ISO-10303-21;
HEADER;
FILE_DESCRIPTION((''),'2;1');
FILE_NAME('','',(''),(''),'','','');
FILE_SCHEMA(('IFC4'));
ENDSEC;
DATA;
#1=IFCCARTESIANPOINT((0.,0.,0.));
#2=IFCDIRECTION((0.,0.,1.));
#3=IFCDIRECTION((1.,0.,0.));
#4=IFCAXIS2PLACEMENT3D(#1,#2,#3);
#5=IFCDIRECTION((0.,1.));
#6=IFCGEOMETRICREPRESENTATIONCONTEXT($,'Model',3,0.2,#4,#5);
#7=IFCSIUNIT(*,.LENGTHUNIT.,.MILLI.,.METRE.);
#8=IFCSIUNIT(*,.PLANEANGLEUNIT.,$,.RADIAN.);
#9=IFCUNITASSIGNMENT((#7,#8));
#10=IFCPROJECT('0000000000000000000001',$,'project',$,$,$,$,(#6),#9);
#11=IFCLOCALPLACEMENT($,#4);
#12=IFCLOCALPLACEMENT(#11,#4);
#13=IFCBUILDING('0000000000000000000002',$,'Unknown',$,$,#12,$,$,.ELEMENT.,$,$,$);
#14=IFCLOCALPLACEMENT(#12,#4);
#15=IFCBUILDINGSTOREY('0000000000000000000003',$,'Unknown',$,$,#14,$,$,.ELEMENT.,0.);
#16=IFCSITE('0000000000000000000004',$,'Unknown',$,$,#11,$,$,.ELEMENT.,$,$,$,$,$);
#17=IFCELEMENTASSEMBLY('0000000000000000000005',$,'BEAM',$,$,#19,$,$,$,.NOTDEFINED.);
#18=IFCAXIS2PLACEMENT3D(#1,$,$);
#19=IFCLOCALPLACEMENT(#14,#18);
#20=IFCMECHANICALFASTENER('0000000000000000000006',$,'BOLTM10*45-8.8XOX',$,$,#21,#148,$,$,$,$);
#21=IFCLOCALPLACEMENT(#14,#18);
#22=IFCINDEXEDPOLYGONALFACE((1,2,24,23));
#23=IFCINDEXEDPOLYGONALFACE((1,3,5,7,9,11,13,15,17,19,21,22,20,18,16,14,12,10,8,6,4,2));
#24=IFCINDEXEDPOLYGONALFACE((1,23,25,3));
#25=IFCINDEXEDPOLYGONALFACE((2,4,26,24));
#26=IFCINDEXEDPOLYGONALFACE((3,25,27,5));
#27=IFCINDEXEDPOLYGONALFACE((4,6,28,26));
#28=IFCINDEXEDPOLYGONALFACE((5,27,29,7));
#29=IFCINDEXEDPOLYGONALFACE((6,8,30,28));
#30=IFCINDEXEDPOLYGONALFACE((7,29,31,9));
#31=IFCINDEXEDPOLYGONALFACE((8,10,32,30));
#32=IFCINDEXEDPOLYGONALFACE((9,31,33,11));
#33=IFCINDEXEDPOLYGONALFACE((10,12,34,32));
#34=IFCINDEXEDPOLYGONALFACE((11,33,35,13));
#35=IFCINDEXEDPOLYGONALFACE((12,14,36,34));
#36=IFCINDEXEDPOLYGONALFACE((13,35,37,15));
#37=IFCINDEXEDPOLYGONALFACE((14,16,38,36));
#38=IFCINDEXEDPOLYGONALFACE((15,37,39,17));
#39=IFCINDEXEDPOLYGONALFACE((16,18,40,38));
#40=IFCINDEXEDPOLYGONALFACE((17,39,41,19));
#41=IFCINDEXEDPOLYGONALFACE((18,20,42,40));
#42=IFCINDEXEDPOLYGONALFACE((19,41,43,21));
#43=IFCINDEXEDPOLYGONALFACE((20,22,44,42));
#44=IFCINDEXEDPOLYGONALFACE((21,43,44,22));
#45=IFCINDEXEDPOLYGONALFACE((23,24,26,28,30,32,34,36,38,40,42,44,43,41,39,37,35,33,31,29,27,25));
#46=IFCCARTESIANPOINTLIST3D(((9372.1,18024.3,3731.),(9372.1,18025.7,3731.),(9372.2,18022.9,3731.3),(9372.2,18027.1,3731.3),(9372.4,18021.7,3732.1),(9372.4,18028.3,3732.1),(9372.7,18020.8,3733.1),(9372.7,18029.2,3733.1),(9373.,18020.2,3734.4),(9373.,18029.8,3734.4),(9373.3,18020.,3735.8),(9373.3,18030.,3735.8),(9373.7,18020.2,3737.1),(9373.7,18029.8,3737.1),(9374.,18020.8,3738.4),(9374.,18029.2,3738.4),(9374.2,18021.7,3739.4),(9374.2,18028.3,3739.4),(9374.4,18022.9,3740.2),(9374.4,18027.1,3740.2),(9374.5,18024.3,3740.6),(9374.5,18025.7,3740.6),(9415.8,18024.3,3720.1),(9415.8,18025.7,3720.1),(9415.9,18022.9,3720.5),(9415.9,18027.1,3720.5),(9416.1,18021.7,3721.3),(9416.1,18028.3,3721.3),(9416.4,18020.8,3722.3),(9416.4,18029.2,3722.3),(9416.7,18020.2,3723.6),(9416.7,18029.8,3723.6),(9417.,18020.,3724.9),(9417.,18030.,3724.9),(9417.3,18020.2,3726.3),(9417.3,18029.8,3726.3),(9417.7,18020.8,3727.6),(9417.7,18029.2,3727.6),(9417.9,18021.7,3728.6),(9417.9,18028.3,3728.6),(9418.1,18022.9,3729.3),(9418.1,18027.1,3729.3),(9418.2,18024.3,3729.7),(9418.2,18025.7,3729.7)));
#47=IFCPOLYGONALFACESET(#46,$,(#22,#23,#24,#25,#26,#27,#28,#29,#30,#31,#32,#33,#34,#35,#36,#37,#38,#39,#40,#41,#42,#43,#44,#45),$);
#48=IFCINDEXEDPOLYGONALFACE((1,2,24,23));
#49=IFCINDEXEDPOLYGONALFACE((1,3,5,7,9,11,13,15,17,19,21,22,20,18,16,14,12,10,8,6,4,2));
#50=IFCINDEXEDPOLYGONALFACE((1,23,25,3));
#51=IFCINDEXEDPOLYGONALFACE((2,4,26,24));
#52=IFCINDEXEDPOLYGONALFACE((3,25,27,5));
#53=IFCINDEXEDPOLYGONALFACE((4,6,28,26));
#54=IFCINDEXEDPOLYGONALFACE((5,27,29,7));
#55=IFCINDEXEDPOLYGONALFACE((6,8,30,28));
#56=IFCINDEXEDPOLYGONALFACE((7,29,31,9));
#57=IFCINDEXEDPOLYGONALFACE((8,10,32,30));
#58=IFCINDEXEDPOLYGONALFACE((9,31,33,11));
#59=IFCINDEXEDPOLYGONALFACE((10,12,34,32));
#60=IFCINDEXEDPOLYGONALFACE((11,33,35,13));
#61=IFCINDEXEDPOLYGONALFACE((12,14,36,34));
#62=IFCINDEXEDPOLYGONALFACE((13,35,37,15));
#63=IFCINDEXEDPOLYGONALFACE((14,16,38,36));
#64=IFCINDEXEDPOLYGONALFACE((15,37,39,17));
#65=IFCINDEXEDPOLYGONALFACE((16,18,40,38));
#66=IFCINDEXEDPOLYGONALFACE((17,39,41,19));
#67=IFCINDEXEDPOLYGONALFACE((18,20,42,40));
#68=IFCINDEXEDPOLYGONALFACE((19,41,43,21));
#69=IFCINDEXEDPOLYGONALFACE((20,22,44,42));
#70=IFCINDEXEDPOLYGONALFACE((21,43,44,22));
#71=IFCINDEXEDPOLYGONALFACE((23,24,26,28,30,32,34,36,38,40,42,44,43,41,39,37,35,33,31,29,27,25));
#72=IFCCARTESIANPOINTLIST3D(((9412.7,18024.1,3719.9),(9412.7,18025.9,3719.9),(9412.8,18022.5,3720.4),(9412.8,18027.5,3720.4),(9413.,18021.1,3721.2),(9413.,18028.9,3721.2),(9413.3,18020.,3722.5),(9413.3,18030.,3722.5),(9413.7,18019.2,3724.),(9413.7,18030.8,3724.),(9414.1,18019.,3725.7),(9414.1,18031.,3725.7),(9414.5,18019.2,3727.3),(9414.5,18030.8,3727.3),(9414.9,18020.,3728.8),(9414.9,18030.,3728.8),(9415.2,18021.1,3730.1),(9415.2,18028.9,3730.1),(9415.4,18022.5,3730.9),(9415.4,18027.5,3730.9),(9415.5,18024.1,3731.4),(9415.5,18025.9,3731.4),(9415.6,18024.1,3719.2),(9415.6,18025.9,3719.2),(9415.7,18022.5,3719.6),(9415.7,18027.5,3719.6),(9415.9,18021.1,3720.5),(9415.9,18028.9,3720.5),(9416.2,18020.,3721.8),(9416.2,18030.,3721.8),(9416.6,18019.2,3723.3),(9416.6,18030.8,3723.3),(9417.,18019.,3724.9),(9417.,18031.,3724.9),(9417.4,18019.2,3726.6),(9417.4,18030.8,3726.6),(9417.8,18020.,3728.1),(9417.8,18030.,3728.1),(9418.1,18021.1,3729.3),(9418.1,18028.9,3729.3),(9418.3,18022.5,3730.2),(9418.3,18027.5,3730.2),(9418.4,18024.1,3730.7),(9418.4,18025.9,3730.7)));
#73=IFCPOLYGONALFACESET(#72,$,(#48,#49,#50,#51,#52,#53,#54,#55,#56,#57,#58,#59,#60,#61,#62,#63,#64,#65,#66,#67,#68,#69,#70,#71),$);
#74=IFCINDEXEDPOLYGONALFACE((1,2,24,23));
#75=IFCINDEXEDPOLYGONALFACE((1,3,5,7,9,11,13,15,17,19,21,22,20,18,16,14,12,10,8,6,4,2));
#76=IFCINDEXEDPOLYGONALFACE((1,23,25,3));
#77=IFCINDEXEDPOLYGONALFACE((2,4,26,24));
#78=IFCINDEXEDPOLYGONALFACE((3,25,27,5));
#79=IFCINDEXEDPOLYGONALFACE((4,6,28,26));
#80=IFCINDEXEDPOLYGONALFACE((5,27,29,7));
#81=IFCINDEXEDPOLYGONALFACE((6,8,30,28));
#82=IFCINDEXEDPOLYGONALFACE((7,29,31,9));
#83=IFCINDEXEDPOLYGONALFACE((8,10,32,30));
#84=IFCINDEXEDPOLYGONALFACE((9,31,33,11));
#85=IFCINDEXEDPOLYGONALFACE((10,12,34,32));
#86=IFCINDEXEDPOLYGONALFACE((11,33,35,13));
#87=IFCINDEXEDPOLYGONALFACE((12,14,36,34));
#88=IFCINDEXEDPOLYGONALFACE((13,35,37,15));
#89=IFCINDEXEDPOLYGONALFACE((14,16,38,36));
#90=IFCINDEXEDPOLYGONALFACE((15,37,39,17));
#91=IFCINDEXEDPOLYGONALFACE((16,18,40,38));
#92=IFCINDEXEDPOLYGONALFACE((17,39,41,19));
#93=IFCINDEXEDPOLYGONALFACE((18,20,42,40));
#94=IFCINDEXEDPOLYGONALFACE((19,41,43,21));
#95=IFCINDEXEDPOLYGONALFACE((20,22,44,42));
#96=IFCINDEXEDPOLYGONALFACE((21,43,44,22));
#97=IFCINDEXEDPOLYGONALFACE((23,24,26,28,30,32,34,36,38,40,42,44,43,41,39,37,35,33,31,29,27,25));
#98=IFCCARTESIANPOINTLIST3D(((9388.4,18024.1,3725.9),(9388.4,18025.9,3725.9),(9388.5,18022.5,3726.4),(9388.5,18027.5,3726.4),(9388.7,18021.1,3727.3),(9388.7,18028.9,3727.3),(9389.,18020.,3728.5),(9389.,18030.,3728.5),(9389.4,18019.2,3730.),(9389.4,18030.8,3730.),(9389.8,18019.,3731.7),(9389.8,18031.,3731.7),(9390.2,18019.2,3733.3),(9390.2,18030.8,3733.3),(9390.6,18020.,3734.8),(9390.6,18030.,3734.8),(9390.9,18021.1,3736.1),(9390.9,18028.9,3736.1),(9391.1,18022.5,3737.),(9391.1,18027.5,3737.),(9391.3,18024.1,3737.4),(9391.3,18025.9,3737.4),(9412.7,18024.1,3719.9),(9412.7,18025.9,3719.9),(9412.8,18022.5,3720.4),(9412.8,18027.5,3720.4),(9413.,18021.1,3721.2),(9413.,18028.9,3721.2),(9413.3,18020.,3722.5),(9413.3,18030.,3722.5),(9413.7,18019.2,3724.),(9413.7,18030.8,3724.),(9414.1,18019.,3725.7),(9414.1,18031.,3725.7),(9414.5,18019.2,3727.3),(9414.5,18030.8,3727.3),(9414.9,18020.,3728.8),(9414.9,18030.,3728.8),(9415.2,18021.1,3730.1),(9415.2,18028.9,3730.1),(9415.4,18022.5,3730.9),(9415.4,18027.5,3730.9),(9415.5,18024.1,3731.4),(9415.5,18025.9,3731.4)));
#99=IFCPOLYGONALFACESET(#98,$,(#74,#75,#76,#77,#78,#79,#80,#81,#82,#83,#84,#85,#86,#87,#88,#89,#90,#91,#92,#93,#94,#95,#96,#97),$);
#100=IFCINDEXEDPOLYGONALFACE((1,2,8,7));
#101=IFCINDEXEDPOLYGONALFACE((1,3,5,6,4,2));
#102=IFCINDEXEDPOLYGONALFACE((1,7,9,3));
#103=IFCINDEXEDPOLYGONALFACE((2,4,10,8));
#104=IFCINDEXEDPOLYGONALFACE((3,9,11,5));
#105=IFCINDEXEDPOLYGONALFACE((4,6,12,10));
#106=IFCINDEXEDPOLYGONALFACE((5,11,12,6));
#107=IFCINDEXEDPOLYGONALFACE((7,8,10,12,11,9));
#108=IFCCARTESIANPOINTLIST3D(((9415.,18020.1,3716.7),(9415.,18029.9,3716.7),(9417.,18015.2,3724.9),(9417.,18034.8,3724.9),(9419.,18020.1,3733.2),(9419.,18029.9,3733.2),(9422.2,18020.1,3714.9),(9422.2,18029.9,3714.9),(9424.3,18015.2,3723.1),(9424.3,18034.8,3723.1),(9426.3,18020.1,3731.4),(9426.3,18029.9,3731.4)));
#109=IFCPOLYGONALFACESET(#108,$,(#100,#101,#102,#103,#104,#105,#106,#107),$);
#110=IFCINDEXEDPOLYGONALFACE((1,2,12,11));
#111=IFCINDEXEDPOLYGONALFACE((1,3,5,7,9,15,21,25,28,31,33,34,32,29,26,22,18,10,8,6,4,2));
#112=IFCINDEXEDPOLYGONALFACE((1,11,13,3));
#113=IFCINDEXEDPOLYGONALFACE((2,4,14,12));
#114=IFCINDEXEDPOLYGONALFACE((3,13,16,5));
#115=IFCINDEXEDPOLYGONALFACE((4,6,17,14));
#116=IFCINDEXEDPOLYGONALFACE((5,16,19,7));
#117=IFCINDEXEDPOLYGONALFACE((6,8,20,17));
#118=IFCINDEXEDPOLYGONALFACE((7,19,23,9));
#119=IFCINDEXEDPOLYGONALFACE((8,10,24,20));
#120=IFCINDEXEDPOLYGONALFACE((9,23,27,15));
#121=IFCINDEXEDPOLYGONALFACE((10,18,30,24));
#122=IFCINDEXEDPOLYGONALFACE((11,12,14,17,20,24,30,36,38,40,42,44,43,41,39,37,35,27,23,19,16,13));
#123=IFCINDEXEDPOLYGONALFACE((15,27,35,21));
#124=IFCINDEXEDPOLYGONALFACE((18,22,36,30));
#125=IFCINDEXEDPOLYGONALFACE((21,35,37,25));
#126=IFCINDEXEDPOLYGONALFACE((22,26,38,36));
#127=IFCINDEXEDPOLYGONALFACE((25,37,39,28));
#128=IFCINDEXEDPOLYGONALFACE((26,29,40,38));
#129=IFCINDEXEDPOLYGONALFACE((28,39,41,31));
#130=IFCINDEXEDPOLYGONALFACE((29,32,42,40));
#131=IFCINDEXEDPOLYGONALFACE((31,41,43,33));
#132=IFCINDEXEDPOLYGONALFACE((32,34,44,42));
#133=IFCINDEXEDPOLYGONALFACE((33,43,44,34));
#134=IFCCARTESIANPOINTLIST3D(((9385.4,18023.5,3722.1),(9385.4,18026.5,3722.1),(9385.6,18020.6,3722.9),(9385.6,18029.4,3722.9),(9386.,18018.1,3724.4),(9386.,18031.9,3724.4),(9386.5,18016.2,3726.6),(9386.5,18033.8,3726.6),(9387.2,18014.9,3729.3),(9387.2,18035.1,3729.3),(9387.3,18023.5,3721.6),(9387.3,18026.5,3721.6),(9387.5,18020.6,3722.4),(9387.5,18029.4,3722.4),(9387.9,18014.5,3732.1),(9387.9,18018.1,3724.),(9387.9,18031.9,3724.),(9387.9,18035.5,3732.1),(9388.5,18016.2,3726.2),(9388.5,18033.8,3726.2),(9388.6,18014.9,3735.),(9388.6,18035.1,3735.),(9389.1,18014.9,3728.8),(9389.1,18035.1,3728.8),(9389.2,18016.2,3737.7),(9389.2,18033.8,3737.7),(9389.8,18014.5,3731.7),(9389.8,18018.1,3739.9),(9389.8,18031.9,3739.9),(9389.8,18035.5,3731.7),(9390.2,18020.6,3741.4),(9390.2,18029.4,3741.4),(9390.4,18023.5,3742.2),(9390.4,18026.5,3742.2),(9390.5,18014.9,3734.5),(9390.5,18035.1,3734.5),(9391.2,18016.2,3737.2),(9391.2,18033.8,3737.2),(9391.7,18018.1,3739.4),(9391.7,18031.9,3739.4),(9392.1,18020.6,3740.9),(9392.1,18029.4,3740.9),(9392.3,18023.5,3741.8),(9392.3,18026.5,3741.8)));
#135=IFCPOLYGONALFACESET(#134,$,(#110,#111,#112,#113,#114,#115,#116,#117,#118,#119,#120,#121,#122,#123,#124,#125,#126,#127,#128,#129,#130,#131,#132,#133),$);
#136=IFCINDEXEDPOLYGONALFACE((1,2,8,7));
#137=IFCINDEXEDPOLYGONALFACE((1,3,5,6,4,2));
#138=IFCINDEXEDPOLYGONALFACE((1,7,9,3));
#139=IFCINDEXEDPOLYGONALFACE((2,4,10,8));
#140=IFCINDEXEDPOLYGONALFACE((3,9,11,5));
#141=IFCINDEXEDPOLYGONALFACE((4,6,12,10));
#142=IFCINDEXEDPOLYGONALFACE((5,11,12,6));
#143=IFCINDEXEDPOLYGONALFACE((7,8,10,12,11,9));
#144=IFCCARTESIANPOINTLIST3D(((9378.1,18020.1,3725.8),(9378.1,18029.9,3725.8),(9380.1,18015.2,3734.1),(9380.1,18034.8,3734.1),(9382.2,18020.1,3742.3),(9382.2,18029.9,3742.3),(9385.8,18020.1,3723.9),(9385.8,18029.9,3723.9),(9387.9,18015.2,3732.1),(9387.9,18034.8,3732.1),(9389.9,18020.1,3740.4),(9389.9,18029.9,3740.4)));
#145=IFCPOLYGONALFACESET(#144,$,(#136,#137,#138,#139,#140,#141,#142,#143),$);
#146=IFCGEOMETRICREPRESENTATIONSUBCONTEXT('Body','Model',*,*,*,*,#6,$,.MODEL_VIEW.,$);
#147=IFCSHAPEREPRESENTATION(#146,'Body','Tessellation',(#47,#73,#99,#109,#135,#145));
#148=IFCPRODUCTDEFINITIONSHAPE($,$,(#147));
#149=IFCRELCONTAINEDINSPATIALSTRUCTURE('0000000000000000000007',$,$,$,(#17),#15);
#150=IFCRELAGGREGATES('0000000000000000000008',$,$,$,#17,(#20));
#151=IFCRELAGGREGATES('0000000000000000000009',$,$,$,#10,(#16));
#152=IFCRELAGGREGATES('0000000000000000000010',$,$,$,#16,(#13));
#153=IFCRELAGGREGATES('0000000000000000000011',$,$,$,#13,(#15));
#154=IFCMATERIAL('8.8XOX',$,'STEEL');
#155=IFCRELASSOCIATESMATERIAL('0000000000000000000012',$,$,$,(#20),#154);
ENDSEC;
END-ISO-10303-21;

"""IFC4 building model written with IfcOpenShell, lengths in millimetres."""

from ifc_helpers import new_model, si_unit, direction, frame, origin_with_axes, place, context, subcontext, project, spatial, line, arc, indexed_curve, outline, extrude, source, transform, mapped, material, element, aggregate, save


model = new_model("IFC4")

# Units and contexts
model_context = context("Model", 3, precision=0.2, world=origin_with_axes(), true_north=direction((0.0, 1.0)))
body_context = subcontext(model_context, "Body", "Model", "MODEL_VIEW")
ifc_project = project(units=[si_unit("LENGTHUNIT", "METRE", prefix="MILLI"), si_unit("PLANEANGLEUNIT", "RADIAN")], contexts=[model_context])

# Site, building, storey
site_placement = place(None, origin_with_axes())
site = spatial("IfcSite", under=ifc_project, at=site_placement, Name="Unknown", CompositionType="ELEMENT")
building_placement = place(site_placement, origin_with_axes())
building = spatial("IfcBuilding", under=site, at=building_placement, Name="Unknown", CompositionType="ELEMENT")
storey_placement = place(building_placement, origin_with_axes())
storey = spatial("IfcBuildingStorey", under=building, at=storey_placement, Name="Unknown", CompositionType="ELEMENT", Elevation=0.0)

# Shared definitions
ifc_material_1 = material(Name="8.8XOX", Category="STEEL")

# Element assembly, mechanical fastener
shared_shape_1 = source(origin_with_axes(), body_context, "Body", "SweptSolid", [
    extrude(outline(indexed_curve([(5.0, 0.0), (0.0, 5.0), (-5.0, 0.0), (0.0, -5.0)], segments=[arc(1, 2, 3), arc(3, 4, 1)])), frame((0.0, 0.0, 3.8), z_axis=(0.0, 0.0, -1.0), x_axis=(0.0, 1.0, 0.0)), (0.0, 0.0, 1.0), 45.0),
    extrude(outline(indexed_curve([(6.0, 0.0), (0.0, 6.0), (-6.0, 0.0), (0.0, -6.0)], segments=[arc(1, 2, 3), arc(3, 4, 1)])), frame((0.0, 0.0, 3.8), z_axis=(0.0, 0.0, -1.0), x_axis=(0.0, 1.0, 0.0)), (0.0, 0.0, 1.0), 3.0),
    extrude(outline(indexed_curve([(6.0, 0.0), (0.0, 6.0), (-6.0, 0.0), (0.0, -6.0)], segments=[arc(1, 2, 3), arc(3, 4, 1)])), frame((0.0, 0.0, 0.8), z_axis=(0.0, 0.0, -1.0), x_axis=(0.0, 1.0, 0.0)), (0.0, 0.0, 1.0), 25.0),
    extrude(outline(indexed_curve([(9.8, 0.0), (4.9, 8.5), (-4.9, 8.5), (-9.8, 0.0), (-4.9, -8.5), (4.9, -8.5)], segments=[line(1, 2, 3, 4, 5, 6, 1)])), frame((0.0, 0.0, 11.2), z_axis=(0.0, 0.0, -1.0), x_axis=(0.0, 1.0, 0.0)), (0.0, 0.0, 1.0), 7.5),
    extrude(outline(indexed_curve([(10.5, 0.0), (0.0, 10.5), (-10.5, 0.0), (0.0, -10.5)], segments=[arc(1, 2, 3), arc(3, 4, 1)])), frame((0.0, 0.0, -24.2), z_axis=(0.0, 0.0, -1.0), x_axis=(0.0, 1.0, 0.0)), (0.0, 0.0, 1.0), 2.0),
    extrude(outline(indexed_curve([(9.8, 0.0), (4.9, 8.5), (-4.9, 8.5), (-9.8, 0.0), (-4.9, -8.5), (4.9, -8.5)], segments=[line(1, 2, 3, 4, 5, 6, 1)])), frame((0.0, 0.0, -26.2), z_axis=(0.0, 0.0, -1.0), x_axis=(0.0, 1.0, 0.0)), (0.0, 0.0, 1.0), 8.0),
])
assembly_1_placement = place(storey_placement, frame((9403.2, 18000.0, 3733.5), z_axis=(0.970613, 0.0, -0.240648), x_axis=(0.0, 1.0, 0.0)))
assembly_1 = element("IfcElementAssembly", 1, at=assembly_1_placement, inside=storey, Name="BEAM", PredefinedType="NOTDEFINED")
mechanical_fastener_1_placement = place(assembly_1_placement, frame((25.0, -5.0, 11.8), z_axis=(0.0, 0.0, 1.0), x_axis=(0.0, 1.0, 0.0)))
mechanical_fastener_1 = element("IfcMechanicalFastener", 2, at=mechanical_fastener_1_placement, material=ifc_material_1, Name="BOLTM10*45-8.8XOX", context=body_context, shape_type="MappedRepresentation", body=[
    mapped(shared_shape_1, transform((0.0, 0.0, 0.0))),
])
aggregate(assembly_1, [mechanical_fastener_1])

save(model, "model.ifc")
